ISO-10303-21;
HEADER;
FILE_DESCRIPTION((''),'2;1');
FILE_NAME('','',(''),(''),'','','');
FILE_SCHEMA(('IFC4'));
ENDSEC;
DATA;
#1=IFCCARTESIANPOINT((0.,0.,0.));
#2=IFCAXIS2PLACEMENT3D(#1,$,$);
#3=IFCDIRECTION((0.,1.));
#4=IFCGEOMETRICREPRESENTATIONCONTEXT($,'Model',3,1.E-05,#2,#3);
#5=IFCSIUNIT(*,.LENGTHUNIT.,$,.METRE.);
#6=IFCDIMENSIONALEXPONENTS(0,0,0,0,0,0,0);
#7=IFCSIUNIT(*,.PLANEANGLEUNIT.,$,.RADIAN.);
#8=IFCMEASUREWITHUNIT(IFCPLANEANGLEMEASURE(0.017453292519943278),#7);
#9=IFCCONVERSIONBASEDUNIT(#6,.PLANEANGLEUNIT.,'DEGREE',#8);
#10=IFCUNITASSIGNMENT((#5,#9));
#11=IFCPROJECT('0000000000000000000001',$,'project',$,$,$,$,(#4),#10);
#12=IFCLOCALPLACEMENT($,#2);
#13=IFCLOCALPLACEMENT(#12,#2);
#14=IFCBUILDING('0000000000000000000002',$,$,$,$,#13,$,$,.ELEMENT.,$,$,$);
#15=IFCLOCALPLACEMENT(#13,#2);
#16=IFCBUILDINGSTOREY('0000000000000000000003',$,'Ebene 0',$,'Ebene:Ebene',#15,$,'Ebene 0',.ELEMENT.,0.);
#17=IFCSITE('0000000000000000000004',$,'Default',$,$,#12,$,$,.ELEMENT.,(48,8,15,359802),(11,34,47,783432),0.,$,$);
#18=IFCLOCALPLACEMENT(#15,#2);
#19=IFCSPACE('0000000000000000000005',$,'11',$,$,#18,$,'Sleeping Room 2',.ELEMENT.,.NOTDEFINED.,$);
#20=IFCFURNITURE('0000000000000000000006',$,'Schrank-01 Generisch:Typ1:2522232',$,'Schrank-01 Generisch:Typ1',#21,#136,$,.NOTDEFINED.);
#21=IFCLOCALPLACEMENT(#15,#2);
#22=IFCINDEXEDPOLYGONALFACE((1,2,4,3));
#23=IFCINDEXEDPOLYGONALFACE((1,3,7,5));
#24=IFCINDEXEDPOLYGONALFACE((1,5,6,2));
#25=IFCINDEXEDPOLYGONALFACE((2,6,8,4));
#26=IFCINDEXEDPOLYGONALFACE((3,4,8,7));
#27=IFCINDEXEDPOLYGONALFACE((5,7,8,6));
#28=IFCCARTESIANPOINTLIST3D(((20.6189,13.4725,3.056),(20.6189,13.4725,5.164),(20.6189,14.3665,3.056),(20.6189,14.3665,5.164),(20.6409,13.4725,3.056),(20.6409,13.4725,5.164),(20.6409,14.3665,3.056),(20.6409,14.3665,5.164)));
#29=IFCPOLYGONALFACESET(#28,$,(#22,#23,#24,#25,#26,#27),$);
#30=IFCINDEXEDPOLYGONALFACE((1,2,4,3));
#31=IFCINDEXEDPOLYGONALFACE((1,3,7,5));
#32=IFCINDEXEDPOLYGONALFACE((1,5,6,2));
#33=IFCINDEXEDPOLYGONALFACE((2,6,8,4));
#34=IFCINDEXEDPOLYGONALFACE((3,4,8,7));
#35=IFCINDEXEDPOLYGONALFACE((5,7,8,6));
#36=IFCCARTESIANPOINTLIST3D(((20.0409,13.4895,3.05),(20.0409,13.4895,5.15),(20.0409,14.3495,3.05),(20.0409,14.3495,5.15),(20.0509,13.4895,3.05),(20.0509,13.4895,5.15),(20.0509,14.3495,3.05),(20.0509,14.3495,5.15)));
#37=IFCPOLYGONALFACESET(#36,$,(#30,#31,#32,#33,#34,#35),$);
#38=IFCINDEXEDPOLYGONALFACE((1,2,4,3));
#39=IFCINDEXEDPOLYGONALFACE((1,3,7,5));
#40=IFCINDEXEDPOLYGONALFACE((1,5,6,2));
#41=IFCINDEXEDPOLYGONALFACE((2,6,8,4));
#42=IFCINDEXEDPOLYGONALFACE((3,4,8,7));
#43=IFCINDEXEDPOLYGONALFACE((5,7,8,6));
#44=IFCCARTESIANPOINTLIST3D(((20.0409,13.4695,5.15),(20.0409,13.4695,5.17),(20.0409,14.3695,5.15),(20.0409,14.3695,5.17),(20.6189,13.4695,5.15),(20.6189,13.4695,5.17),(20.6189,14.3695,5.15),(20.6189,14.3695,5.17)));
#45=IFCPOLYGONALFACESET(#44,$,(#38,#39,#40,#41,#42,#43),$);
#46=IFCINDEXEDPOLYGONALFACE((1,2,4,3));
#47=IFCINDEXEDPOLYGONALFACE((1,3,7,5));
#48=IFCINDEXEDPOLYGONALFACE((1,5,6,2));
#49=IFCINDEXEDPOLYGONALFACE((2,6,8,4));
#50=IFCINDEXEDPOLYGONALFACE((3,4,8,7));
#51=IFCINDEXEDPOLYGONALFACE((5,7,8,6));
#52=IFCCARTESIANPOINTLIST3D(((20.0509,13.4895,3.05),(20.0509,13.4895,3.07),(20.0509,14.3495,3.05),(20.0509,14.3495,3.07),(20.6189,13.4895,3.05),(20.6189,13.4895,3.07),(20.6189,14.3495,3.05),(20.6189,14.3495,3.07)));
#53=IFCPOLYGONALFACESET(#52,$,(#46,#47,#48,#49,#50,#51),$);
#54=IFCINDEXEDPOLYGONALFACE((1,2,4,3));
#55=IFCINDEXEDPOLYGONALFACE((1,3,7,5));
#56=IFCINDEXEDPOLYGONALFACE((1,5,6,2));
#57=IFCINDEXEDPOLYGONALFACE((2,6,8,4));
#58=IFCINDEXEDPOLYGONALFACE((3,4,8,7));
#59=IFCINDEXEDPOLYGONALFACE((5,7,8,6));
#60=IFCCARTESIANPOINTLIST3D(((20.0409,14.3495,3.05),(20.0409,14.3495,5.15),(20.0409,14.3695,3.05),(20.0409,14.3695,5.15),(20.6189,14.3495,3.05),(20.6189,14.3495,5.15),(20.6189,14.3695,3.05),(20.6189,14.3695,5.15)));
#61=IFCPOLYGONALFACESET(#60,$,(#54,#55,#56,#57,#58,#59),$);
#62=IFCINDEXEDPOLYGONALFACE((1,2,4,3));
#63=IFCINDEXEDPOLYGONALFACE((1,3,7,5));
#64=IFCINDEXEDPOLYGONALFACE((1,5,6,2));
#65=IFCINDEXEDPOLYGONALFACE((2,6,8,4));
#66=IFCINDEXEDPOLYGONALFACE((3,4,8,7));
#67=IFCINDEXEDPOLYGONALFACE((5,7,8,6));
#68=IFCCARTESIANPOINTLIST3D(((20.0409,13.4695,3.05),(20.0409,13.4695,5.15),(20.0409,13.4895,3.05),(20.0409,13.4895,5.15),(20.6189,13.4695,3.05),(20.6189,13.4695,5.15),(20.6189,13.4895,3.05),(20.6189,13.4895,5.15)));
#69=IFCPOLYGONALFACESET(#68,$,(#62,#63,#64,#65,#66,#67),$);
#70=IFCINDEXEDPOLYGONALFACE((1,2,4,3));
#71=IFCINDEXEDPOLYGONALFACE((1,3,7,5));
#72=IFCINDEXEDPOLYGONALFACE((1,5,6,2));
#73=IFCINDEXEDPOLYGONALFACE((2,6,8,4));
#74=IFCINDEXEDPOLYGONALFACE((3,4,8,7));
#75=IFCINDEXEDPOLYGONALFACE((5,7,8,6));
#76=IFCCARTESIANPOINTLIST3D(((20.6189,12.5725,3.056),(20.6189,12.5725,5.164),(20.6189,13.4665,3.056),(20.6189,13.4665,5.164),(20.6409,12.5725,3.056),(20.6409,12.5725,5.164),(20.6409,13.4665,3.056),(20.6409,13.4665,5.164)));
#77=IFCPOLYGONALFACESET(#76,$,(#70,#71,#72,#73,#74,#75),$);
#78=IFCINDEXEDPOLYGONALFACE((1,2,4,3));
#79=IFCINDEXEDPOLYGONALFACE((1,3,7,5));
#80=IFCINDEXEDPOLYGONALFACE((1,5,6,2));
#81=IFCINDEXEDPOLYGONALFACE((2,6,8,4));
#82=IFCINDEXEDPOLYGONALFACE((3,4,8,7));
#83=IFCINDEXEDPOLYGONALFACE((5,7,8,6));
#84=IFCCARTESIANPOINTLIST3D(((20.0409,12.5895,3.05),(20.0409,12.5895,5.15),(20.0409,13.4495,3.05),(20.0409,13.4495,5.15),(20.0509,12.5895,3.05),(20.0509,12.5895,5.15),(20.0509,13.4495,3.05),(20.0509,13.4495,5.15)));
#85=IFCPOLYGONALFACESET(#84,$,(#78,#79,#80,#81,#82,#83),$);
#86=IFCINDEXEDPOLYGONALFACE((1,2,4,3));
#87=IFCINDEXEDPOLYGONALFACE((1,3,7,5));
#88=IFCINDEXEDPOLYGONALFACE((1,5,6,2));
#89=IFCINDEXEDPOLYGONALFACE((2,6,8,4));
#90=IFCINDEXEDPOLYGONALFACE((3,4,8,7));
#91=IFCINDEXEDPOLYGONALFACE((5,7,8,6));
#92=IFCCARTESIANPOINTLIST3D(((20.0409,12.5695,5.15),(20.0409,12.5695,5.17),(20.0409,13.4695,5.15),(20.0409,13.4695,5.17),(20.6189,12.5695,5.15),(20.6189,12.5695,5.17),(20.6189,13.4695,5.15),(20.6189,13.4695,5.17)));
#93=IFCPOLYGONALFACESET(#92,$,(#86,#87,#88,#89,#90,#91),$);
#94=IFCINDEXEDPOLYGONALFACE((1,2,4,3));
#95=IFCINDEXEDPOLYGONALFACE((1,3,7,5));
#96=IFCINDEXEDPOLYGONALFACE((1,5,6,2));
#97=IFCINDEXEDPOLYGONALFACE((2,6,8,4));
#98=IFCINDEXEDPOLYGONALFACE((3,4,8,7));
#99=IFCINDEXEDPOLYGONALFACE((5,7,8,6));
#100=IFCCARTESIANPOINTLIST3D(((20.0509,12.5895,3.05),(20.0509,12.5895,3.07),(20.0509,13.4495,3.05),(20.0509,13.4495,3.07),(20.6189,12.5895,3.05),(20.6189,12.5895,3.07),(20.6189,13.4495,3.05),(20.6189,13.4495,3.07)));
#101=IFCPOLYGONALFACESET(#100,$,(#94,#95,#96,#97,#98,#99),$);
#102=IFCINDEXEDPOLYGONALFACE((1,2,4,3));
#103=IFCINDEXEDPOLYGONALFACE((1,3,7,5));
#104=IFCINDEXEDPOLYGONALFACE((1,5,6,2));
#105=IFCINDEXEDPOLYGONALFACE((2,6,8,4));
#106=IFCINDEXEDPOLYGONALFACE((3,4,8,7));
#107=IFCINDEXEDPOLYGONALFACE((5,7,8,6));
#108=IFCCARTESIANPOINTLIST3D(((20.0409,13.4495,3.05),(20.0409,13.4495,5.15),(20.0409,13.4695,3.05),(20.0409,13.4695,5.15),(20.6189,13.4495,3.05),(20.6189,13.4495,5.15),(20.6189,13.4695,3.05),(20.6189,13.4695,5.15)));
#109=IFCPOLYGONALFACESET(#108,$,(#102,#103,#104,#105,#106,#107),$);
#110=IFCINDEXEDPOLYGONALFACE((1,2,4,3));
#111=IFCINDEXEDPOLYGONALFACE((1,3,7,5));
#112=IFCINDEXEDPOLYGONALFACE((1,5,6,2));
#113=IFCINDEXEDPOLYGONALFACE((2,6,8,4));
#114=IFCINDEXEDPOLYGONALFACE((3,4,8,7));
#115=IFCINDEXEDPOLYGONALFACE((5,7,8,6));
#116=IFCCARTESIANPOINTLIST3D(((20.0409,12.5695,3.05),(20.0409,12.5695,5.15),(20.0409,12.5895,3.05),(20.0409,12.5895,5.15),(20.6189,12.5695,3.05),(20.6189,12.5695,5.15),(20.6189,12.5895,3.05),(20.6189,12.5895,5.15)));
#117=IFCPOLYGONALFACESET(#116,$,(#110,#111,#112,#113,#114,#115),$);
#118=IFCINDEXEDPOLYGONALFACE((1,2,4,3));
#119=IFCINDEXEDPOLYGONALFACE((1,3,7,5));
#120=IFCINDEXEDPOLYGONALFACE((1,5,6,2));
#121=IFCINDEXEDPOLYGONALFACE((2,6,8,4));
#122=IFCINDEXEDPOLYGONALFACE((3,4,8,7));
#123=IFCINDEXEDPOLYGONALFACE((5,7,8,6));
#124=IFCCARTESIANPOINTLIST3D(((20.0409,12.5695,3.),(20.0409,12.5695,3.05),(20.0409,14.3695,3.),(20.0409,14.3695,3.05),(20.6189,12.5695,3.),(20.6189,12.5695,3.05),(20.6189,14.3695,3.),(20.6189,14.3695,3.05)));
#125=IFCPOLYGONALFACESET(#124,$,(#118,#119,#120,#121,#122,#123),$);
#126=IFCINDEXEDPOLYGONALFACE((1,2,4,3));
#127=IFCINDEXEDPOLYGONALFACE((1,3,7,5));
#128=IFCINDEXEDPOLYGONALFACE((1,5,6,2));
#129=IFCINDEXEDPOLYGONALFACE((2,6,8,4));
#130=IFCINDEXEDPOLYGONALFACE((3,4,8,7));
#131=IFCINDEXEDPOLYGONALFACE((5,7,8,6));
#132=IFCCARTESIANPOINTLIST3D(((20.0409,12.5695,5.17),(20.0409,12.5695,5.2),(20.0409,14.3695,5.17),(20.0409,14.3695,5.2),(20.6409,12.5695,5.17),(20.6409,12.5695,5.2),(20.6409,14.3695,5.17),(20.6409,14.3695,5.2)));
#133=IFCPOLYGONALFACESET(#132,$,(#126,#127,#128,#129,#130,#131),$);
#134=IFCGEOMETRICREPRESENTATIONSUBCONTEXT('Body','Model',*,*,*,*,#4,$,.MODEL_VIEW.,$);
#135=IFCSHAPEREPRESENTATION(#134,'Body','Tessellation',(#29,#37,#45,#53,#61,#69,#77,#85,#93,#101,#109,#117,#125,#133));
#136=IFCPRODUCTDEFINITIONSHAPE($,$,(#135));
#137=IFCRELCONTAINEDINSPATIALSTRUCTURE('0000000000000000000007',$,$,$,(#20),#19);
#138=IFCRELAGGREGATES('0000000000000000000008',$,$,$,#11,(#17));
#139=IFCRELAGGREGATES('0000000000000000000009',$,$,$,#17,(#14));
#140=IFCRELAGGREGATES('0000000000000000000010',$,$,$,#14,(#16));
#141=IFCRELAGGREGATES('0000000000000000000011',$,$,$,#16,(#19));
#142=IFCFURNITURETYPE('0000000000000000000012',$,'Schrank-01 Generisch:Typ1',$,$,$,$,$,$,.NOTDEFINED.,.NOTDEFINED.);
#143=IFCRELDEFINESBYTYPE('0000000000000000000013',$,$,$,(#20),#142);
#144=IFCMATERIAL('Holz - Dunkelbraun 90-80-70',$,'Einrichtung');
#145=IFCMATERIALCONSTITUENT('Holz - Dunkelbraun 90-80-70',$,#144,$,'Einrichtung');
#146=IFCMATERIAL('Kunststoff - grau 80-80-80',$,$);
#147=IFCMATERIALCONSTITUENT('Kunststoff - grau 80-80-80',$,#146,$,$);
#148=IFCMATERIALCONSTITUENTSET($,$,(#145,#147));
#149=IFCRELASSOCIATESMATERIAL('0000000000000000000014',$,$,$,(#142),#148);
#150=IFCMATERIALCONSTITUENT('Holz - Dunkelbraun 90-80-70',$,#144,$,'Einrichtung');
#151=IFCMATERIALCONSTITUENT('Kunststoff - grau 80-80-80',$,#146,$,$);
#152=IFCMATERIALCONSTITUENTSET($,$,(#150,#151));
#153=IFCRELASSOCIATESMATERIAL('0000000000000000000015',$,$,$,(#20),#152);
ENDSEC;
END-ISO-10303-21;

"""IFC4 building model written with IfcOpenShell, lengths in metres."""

from ifc_helpers import new_model, entity, si_unit, converted_unit, direction, frame, origin, place, context, subcontext, project, spatial, indexed_curve, outline, extrude, source, transform, mapped, material, constituent, constituent_set, type_object, type_shapes, element, save


model = new_model("IFC4")

# Units and contexts
model_context = context("Model", 3, precision=1e-05, world=origin(), true_north=direction((0.0, 1.0)))
body_context = subcontext(model_context, "Body", "Model", "MODEL_VIEW")
ifc_project = project(units=[si_unit("LENGTHUNIT", "METRE"), converted_unit("PLANEANGLEUNIT", "DEGREE", entity("IfcPlaneAngleMeasure", 0.017453292519943278), si_unit("PLANEANGLEUNIT", "RADIAN"), dimensions=[0, 0, 0, 0, 0, 0, 0])], contexts=[model_context])

# Site, building, storey
site_placement = place(None, origin())
site = spatial("IfcSite", under=ifc_project, at=site_placement, Name="Default", CompositionType="ELEMENT", RefLatitude=(48, 8, 15, 359802), RefLongitude=(11, 34, 47, 783432), RefElevation=0.0)
building_placement = place(site_placement, origin())
building = spatial("IfcBuilding", under=site, at=building_placement, CompositionType="ELEMENT")
storey_placement = place(building_placement, origin())
storey = spatial("IfcBuildingStorey", under=building, at=storey_placement, Name="Ebene 0", ObjectType="Ebene:Ebene", LongName="Ebene 0", CompositionType="ELEMENT", Elevation=0.0)

# Shared definitions
ifc_material_1 = material(Name="Holz - Dunkelbraun 90-80-70", Category="Einrichtung")
ifc_material_2 = material(Name="Kunststoff - grau 80-80-80")

# Shared definitions
ifc_constituent_1 = constituent(ifc_material_1, Name="Holz - Dunkelbraun 90-80-70", Category="Einrichtung")
ifc_constituent_2 = constituent(ifc_material_2, Name="Kunststoff - grau 80-80-80")
ifc_constituent_set_1 = constituent_set(constituents=[ifc_constituent_1, ifc_constituent_2])
furniture_type_1 = type_object("IfcFurnitureType", Name="Schrank-01 Generisch:Typ1", AssemblyPlace="NOTDEFINED", PredefinedType="NOTDEFINED", material=ifc_constituent_set_1)
shared_shape_1 = source(origin(), body_context, "Body", "SweptSolid", [
    extrude(outline(indexed_curve([(-0.447, -0.011), (0.447, -0.011), (0.447, 0.011), (-0.447, 0.011), (-0.447, -0.011)], self_intersect=False)), frame((0.45, -0.289, 0.056), z_axis=(0.0, 0.0, 1.0), x_axis=(-1.0, 0.0, 0.0)), (0.0, 0.0, 1.0), 2.108),
    extrude(outline(indexed_curve([(-0.43, -0.005), (0.43, -0.005), (0.43, 0.005), (-0.43, 0.005), (-0.43, -0.005)], self_intersect=False)), frame((0.45, 0.295, 0.05), z_axis=(0.0, 0.0, 1.0), x_axis=(-1.0, 0.0, 0.0)), (0.0, 0.0, 1.0), 2.1),
    extrude(outline(indexed_curve([(-0.45, -0.289), (0.45, -0.289), (0.45, 0.289), (-0.45, 0.289), (-0.45, -0.289)], self_intersect=False)), frame((0.45, 0.011, 2.15), z_axis=(0.0, 0.0, 1.0), x_axis=(-1.0, 0.0, 0.0)), (0.0, 0.0, 1.0), 0.02),
    extrude(outline(indexed_curve([(-0.43, -0.284), (0.43, -0.284), (0.43, 0.284), (-0.43, 0.284), (-0.43, -0.284)], self_intersect=False)), frame((0.45, 0.006, 0.05), z_axis=(0.0, 0.0, 1.0), x_axis=(-1.0, 0.0, 0.0)), (0.0, 0.0, 1.0), 0.02),
    extrude(outline(indexed_curve([(-0.01, -0.289), (0.01, -0.289), (0.01, 0.289), (-0.01, 0.289), (-0.01, -0.289)], self_intersect=False)), frame((0.89, 0.011, 0.05), z_axis=(0.0, 0.0, 1.0), x_axis=(-1.0, 0.0, 0.0)), (0.0, 0.0, 1.0), 2.1),
    extrude(outline(indexed_curve([(-0.01, -0.289), (0.01, -0.289), (0.01, 0.289), (-0.01, 0.289), (-0.01, -0.289)], self_intersect=False)), frame((0.01, 0.011, 0.05), z_axis=(0.0, 0.0, 1.0), x_axis=(-1.0, 0.0, 0.0)), (0.0, 0.0, 1.0), 2.1),
    extrude(outline(indexed_curve([(-0.447, -0.011), (0.447, -0.011), (0.447, 0.011), (-0.447, 0.011), (-0.447, -0.011)], self_intersect=False)), frame((-0.45, -0.289, 0.056), z_axis=(0.0, 0.0, 1.0), x_axis=(-1.0, 0.0, 0.0)), (0.0, 0.0, 1.0), 2.108),
    extrude(outline(indexed_curve([(-0.43, -0.005), (0.43, -0.005), (0.43, 0.005), (-0.43, 0.005), (-0.43, -0.005)], self_intersect=False)), frame((-0.45, 0.295, 0.05), z_axis=(0.0, 0.0, 1.0), x_axis=(-1.0, 0.0, 0.0)), (0.0, 0.0, 1.0), 2.1),
    extrude(outline(indexed_curve([(-0.45, -0.289), (0.45, -0.289), (0.45, 0.289), (-0.45, 0.289), (-0.45, -0.289)], self_intersect=False)), frame((-0.45, 0.011, 2.15), z_axis=(0.0, 0.0, 1.0), x_axis=(-1.0, 0.0, 0.0)), (0.0, 0.0, 1.0), 0.02),
    extrude(outline(indexed_curve([(-0.43, -0.284), (0.43, -0.284), (0.43, 0.284), (-0.43, 0.284), (-0.43, -0.284)], self_intersect=False)), frame((-0.45, 0.006, 0.05), z_axis=(0.0, 0.0, 1.0), x_axis=(-1.0, 0.0, 0.0)), (0.0, 0.0, 1.0), 0.02),
    extrude(outline(indexed_curve([(-0.01, -0.289), (0.01, -0.289), (0.01, 0.289), (-0.01, 0.289), (-0.01, -0.289)], self_intersect=False)), frame((-0.01, 0.011, 0.05), z_axis=(0.0, 0.0, 1.0), x_axis=(-1.0, 0.0, 0.0)), (0.0, 0.0, 1.0), 2.1),
    extrude(outline(indexed_curve([(-0.01, -0.289), (0.01, -0.289), (0.01, 0.289), (-0.01, 0.289), (-0.01, -0.289)], self_intersect=False)), frame((-0.89, 0.011, 0.05), z_axis=(0.0, 0.0, 1.0), x_axis=(-1.0, 0.0, 0.0)), (0.0, 0.0, 1.0), 2.1),
    extrude(outline(indexed_curve([(-0.9, -0.289), (0.9, -0.289), (0.9, 0.289), (-0.9, 0.289), (-0.9, -0.289)], self_intersect=False)), frame((0.0, 0.011, 0.0), z_axis=(0.0, 0.0, 1.0), x_axis=(-1.0, 0.0, 0.0)), (0.0, 0.0, 1.0), 0.05),
    extrude(outline(indexed_curve([(-0.9, -0.3), (0.9, -0.3), (0.9, 0.3), (-0.9, 0.3), (-0.9, -0.3)], self_intersect=False)), frame((0.0, 0.0, 2.17), z_axis=(0.0, 0.0, 1.0), x_axis=(-1.0, 0.0, 0.0)), (0.0, 0.0, 1.0), 0.03),
])
type_shapes(furniture_type_1, [shared_shape_1])

# Shared definitions
space_1_placement = place(storey_placement, origin())
space_1 = spatial("IfcSpace", under=storey, at=space_1_placement, Name="11", LongName="Sleeping Room 2", CompositionType="ELEMENT", PredefinedType="NOTDEFINED")

# Furniture
ifc_constituent_3 = constituent(ifc_material_1, Name="Holz - Dunkelbraun 90-80-70", Category="Einrichtung")
ifc_constituent_4 = constituent(ifc_material_2, Name="Kunststoff - grau 80-80-80")
ifc_constituent_set_2 = constituent_set(constituents=[ifc_constituent_3, ifc_constituent_4])
furniture_1_placement = place(space_1_placement, frame((20.3409, 13.4695, 3.0), z_axis=(0.0, 0.0, 1.0), x_axis=(0.0, 1.0, 0.0)))
element("IfcFurniture", 1, at=furniture_1_placement, inside=space_1, type_object=furniture_type_1, material=ifc_constituent_set_2, Name="Schrank-01 Generisch:Typ1:2522232", ObjectType="Schrank-01 Generisch:Typ1", PredefinedType="NOTDEFINED", context=body_context, shape_type="MappedRepresentation", body=[
    mapped(shared_shape_1, transform((0.0, 0.0, 0.0), scale=1.0)),
])

save(model, "model.ifc")
